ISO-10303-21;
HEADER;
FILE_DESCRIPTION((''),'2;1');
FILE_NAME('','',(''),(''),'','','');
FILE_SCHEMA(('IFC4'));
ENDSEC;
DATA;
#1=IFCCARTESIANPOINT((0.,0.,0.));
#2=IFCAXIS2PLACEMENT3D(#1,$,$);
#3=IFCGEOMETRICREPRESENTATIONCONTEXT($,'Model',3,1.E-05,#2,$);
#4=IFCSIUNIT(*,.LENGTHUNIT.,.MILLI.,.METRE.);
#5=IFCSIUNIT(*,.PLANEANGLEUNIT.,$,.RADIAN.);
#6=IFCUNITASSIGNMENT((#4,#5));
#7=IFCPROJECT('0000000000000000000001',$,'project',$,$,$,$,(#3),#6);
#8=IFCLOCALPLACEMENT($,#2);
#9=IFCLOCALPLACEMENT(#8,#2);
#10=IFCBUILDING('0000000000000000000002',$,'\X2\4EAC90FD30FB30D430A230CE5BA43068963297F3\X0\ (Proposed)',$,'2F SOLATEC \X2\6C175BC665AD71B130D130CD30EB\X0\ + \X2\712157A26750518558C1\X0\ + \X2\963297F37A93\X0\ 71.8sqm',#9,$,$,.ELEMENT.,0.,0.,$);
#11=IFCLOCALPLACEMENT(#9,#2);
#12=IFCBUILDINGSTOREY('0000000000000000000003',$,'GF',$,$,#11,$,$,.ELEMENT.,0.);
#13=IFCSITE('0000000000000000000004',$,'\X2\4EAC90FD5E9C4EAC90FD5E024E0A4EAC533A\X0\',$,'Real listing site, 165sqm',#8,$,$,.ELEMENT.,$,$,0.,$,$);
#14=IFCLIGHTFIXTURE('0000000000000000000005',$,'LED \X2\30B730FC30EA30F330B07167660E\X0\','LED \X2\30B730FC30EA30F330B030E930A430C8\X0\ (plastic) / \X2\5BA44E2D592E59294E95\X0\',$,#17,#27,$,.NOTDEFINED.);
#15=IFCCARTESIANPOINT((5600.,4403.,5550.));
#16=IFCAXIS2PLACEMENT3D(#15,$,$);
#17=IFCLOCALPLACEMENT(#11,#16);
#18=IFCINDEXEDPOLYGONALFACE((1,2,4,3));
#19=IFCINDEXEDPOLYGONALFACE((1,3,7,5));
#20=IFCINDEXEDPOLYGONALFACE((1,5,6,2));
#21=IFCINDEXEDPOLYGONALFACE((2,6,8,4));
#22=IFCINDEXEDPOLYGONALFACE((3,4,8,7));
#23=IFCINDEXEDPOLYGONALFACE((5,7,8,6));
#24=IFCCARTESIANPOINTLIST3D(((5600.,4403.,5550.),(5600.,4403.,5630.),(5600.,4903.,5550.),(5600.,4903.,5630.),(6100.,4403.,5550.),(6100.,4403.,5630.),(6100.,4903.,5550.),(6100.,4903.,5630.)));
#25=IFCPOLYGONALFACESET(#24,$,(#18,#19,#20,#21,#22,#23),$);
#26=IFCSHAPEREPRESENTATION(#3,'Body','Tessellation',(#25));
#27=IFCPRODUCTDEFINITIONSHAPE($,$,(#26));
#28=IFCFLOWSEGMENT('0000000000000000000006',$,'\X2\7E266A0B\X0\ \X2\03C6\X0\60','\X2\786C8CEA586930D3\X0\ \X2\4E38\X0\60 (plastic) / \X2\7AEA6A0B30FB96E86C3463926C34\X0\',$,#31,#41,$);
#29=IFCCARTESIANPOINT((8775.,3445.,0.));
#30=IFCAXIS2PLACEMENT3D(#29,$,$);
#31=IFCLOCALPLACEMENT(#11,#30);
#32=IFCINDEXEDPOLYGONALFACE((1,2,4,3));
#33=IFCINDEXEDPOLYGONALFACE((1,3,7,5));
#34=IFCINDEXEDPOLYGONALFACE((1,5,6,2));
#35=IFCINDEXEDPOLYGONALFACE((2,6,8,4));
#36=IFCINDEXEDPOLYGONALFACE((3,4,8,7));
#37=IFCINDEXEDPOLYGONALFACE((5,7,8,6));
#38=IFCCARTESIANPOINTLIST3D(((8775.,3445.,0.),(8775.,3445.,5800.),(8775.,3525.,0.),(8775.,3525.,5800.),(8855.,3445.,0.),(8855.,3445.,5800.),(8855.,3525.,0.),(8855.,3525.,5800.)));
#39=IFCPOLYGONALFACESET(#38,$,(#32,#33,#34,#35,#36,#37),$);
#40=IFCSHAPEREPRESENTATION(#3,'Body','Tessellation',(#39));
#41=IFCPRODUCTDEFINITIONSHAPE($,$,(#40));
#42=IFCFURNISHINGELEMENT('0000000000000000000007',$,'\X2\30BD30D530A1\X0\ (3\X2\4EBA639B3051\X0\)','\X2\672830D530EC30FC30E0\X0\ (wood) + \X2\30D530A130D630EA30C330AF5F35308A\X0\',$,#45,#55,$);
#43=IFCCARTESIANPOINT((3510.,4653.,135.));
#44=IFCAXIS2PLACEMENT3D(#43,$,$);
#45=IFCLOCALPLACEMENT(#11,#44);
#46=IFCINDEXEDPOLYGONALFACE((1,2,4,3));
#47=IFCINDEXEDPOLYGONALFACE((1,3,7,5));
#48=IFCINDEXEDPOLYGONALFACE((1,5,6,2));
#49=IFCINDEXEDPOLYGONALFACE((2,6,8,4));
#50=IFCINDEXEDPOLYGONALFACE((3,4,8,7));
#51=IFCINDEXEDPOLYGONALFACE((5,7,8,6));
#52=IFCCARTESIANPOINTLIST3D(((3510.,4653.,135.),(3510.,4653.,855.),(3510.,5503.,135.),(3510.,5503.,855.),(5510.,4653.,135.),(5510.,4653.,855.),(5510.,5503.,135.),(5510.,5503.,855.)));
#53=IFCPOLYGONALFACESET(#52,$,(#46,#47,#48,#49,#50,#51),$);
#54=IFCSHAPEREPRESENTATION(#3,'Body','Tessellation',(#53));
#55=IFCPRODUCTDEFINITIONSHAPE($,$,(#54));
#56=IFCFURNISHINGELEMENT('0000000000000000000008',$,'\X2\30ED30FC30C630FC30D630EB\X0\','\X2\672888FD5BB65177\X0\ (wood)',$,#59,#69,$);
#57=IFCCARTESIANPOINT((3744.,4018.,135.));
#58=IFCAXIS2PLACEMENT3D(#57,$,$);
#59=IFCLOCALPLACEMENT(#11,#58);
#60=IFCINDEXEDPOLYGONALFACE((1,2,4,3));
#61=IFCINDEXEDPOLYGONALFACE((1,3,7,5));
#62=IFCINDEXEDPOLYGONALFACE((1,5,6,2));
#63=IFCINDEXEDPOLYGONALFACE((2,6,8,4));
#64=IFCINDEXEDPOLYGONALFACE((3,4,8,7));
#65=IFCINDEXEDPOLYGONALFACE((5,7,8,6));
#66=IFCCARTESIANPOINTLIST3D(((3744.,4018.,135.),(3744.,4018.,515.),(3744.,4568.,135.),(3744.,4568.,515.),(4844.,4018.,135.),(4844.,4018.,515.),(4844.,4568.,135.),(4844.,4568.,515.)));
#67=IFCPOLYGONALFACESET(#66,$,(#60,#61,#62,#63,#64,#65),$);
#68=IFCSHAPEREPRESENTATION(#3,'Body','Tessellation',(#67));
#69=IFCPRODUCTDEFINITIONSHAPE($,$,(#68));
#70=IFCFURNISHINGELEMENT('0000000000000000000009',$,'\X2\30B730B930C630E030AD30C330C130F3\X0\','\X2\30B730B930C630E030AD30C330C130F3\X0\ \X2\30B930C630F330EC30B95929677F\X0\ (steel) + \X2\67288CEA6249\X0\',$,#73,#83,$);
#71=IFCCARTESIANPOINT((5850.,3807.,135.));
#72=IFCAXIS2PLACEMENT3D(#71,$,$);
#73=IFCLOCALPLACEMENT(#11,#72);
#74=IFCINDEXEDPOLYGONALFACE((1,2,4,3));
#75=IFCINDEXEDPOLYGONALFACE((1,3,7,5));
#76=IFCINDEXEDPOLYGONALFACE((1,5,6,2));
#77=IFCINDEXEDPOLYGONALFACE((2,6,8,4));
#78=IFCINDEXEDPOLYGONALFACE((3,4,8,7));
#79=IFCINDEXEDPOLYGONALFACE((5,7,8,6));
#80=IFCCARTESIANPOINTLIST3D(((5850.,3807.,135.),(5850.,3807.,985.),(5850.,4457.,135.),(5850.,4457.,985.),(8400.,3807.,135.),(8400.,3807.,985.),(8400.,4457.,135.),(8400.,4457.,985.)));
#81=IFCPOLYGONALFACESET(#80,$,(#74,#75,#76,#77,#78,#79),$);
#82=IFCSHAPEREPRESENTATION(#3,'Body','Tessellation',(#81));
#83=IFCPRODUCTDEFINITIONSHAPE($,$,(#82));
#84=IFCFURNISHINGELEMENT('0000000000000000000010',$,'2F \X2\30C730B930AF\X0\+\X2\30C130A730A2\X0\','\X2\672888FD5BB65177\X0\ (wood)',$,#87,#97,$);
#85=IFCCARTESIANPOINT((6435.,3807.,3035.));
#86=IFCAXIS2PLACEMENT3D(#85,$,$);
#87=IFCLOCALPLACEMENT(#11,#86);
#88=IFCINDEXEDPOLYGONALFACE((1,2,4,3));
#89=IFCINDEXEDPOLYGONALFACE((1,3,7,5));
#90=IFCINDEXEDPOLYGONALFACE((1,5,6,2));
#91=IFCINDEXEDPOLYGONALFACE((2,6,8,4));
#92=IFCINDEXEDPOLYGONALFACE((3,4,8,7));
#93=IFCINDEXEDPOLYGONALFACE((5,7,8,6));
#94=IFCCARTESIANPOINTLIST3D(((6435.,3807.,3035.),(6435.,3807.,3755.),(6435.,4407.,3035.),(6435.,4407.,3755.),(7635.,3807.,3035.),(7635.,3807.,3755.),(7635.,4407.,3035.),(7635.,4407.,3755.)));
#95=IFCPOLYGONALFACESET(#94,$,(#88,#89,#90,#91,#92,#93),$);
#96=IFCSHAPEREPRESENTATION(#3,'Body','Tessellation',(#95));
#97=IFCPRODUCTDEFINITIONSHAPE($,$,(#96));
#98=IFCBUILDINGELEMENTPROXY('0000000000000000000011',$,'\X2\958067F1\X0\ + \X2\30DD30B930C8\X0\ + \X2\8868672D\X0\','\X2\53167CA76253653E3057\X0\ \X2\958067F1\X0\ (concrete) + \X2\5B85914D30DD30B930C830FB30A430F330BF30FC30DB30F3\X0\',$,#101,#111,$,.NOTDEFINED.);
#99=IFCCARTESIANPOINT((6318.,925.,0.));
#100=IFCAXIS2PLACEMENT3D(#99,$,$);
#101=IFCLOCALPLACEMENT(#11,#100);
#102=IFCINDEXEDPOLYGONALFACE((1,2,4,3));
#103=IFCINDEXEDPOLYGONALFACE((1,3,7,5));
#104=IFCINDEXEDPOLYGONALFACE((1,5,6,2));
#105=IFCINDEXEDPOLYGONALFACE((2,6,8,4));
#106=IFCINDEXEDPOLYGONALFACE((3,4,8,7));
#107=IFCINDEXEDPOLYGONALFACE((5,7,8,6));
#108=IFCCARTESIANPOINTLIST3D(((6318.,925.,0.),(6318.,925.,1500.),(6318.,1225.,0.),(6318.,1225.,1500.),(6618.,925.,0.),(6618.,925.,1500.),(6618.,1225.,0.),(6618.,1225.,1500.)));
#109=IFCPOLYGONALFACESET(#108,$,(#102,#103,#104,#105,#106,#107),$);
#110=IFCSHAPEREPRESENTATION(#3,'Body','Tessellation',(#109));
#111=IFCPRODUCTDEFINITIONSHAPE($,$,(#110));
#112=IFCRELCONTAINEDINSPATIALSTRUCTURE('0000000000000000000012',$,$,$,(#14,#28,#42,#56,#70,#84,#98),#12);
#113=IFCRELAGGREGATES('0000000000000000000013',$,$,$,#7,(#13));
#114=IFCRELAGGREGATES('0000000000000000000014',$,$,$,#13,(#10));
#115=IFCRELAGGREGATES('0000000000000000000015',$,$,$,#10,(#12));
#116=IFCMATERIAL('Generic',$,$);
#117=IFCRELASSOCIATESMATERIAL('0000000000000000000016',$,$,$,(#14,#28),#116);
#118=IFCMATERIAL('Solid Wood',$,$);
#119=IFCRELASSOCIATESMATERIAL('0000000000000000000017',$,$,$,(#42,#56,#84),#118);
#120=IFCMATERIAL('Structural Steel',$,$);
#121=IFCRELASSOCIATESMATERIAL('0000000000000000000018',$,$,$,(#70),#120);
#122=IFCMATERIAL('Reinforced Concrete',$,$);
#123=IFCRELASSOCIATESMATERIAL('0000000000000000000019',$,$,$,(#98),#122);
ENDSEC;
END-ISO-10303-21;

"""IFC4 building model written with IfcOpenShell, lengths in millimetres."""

from ifc_helpers import new_model, si_unit, frame, frame_2d, origin, place, context, project, spatial, rectangle, extrude, material, element, save


model = new_model("IFC4")

# Units and contexts
model_context = context("Model", 3, precision=1e-05, world=origin())
ifc_project = project(units=[si_unit("LENGTHUNIT", "METRE", prefix="MILLI"), si_unit("PLANEANGLEUNIT", "RADIAN")], contexts=[model_context])

# Site, building, storey
site_placement = place(None, origin())
site = spatial("IfcSite", under=ifc_project, at=site_placement, Name="京都府京都市上京区", ObjectType="Real listing site, 165sqm", CompositionType="ELEMENT", RefElevation=0.0)
building_placement = place(site_placement, origin())
building = spatial("IfcBuilding", under=site, at=building_placement, Name="京都・ピアノ室と防音 (Proposed)", ObjectType="2F SOLATEC 気密断熱パネル + 無垢材内壁 + 防音窓 71.8sqm", CompositionType="ELEMENT", ElevationOfRefHeight=0.0, ElevationOfTerrain=0.0)
storey_placement = place(building_placement, origin())
storey = spatial("IfcBuildingStorey", under=building, at=storey_placement, Name="GF", CompositionType="ELEMENT", Elevation=0.0)

# Shared definitions
ifc_material_1 = material(Name="Solid Wood")

# Shared definitions
ifc_material_2 = material(Name="Reinforced Concrete")

# Shared definitions
ifc_material_3 = material(Name="Structural Steel")

# Shared definitions
ifc_material_4 = material(Name="Generic")

# Light fixture
light_fixture_1_placement = place(storey_placement, frame((5600.0, 4403.0, 5550.0)))
element("IfcLightFixture", 1, at=light_fixture_1_placement, inside=storey, material=ifc_material_4, Name="LED シーリング照明", Description="LED シーリングライト (plastic) / 室中央天井", PredefinedType="NOTDEFINED", context=model_context, shape_type="SweptSolid", body=[
    extrude(rectangle(XDim=500.0, YDim=500.0, at=frame_2d((250.0, 250.0))), frame((5600.0, 4403.0, 5550.0)), (0.0, 0.0, 1.0), 80.0),
])

# Flow segment
flow_segment_placement = place(storey_placement, frame((8775.0, 3445.0, 0.0)))
element("IfcFlowSegment", 2, at=flow_segment_placement, inside=storey, material=ifc_material_4, Name="縦樋 φ60", Description="硬質塩ビ 丸60 (plastic) / 竪樋・雨水排水", context=model_context, shape_type="SweptSolid", body=[
    extrude(rectangle(XDim=80.0, YDim=80.0, at=frame_2d((40.0, 40.0))), frame((8775.0, 3445.0, 0.0)), (0.0, 0.0, 1.0), 5800.0),
])

# Furnishing elements
furnishing_1_placement = place(storey_placement, frame((3510.0, 4653.0, 135.0)))
element("IfcFurnishingElement", 3, at=furnishing_1_placement, inside=storey, material=ifc_material_1, Name="ソファ (3人掛け)", Description="木フレーム (wood) + ファブリック張り", context=model_context, shape_type="SweptSolid", body=[
    extrude(rectangle(XDim=2000.0, YDim=850.0, at=frame_2d((1000.0, 425.0))), frame((3510.0, 4653.0, 135.0)), (0.0, 0.0, 1.0), 720.0),
])
furnishing_2_placement = place(storey_placement, frame((3744.0, 4018.0, 135.0)))
element("IfcFurnishingElement", 4, at=furnishing_2_placement, inside=storey, material=ifc_material_1, Name="ローテーブル", Description="木製家具 (wood)", context=model_context, shape_type="SweptSolid", body=[
    extrude(rectangle(XDim=1100.0, YDim=550.0, at=frame_2d((550.0, 275.0))), frame((3744.0, 4018.0, 135.0)), (0.0, 0.0, 1.0), 380.0),
])
furnishing_3_placement = place(storey_placement, frame((5850.0, 3807.0, 135.0)))
element("IfcFurnishingElement", 5, at=furnishing_3_placement, inside=storey, material=ifc_material_3, Name="システムキッチン", Description="システムキッチン ステンレス天板 (steel) + 木質扉", context=model_context, shape_type="SweptSolid", body=[
    extrude(rectangle(XDim=2550.0, YDim=650.0, at=frame_2d((1275.0, 325.0))), frame((5850.0, 3807.0, 135.0)), (0.0, 0.0, 1.0), 850.0),
])
furnishing_4_placement = place(storey_placement, frame((6435.0, 3807.0, 3035.0)))
element("IfcFurnishingElement", 6, at=furnishing_4_placement, inside=storey, material=ifc_material_1, Name="2F デスク+チェア", Description="木製家具 (wood)", context=model_context, shape_type="SweptSolid", body=[
    extrude(rectangle(XDim=1200.0, YDim=600.0, at=frame_2d((600.0, 300.0))), frame((6435.0, 3807.0, 3035.0)), (0.0, 0.0, 1.0), 720.0),
])

# Building element proxy
proxy_placement = place(storey_placement, frame((6318.0, 925.0, 0.0)))
element("IfcBuildingElementProxy", 7, at=proxy_placement, inside=storey, material=ifc_material_2, Name="門柱 + ポスト + 表札", Description="化粧打放し 門柱 (concrete) + 宅配ポスト・インターホン", PredefinedType="NOTDEFINED", context=model_context, shape_type="SweptSolid", body=[
    extrude(rectangle(XDim=300.0, YDim=300.0, at=frame_2d((150.0, 150.0))), frame((6318.0, 925.0, 0.0)), (0.0, 0.0, 1.0), 1500.0),
])

save(model, "model.ifc")
